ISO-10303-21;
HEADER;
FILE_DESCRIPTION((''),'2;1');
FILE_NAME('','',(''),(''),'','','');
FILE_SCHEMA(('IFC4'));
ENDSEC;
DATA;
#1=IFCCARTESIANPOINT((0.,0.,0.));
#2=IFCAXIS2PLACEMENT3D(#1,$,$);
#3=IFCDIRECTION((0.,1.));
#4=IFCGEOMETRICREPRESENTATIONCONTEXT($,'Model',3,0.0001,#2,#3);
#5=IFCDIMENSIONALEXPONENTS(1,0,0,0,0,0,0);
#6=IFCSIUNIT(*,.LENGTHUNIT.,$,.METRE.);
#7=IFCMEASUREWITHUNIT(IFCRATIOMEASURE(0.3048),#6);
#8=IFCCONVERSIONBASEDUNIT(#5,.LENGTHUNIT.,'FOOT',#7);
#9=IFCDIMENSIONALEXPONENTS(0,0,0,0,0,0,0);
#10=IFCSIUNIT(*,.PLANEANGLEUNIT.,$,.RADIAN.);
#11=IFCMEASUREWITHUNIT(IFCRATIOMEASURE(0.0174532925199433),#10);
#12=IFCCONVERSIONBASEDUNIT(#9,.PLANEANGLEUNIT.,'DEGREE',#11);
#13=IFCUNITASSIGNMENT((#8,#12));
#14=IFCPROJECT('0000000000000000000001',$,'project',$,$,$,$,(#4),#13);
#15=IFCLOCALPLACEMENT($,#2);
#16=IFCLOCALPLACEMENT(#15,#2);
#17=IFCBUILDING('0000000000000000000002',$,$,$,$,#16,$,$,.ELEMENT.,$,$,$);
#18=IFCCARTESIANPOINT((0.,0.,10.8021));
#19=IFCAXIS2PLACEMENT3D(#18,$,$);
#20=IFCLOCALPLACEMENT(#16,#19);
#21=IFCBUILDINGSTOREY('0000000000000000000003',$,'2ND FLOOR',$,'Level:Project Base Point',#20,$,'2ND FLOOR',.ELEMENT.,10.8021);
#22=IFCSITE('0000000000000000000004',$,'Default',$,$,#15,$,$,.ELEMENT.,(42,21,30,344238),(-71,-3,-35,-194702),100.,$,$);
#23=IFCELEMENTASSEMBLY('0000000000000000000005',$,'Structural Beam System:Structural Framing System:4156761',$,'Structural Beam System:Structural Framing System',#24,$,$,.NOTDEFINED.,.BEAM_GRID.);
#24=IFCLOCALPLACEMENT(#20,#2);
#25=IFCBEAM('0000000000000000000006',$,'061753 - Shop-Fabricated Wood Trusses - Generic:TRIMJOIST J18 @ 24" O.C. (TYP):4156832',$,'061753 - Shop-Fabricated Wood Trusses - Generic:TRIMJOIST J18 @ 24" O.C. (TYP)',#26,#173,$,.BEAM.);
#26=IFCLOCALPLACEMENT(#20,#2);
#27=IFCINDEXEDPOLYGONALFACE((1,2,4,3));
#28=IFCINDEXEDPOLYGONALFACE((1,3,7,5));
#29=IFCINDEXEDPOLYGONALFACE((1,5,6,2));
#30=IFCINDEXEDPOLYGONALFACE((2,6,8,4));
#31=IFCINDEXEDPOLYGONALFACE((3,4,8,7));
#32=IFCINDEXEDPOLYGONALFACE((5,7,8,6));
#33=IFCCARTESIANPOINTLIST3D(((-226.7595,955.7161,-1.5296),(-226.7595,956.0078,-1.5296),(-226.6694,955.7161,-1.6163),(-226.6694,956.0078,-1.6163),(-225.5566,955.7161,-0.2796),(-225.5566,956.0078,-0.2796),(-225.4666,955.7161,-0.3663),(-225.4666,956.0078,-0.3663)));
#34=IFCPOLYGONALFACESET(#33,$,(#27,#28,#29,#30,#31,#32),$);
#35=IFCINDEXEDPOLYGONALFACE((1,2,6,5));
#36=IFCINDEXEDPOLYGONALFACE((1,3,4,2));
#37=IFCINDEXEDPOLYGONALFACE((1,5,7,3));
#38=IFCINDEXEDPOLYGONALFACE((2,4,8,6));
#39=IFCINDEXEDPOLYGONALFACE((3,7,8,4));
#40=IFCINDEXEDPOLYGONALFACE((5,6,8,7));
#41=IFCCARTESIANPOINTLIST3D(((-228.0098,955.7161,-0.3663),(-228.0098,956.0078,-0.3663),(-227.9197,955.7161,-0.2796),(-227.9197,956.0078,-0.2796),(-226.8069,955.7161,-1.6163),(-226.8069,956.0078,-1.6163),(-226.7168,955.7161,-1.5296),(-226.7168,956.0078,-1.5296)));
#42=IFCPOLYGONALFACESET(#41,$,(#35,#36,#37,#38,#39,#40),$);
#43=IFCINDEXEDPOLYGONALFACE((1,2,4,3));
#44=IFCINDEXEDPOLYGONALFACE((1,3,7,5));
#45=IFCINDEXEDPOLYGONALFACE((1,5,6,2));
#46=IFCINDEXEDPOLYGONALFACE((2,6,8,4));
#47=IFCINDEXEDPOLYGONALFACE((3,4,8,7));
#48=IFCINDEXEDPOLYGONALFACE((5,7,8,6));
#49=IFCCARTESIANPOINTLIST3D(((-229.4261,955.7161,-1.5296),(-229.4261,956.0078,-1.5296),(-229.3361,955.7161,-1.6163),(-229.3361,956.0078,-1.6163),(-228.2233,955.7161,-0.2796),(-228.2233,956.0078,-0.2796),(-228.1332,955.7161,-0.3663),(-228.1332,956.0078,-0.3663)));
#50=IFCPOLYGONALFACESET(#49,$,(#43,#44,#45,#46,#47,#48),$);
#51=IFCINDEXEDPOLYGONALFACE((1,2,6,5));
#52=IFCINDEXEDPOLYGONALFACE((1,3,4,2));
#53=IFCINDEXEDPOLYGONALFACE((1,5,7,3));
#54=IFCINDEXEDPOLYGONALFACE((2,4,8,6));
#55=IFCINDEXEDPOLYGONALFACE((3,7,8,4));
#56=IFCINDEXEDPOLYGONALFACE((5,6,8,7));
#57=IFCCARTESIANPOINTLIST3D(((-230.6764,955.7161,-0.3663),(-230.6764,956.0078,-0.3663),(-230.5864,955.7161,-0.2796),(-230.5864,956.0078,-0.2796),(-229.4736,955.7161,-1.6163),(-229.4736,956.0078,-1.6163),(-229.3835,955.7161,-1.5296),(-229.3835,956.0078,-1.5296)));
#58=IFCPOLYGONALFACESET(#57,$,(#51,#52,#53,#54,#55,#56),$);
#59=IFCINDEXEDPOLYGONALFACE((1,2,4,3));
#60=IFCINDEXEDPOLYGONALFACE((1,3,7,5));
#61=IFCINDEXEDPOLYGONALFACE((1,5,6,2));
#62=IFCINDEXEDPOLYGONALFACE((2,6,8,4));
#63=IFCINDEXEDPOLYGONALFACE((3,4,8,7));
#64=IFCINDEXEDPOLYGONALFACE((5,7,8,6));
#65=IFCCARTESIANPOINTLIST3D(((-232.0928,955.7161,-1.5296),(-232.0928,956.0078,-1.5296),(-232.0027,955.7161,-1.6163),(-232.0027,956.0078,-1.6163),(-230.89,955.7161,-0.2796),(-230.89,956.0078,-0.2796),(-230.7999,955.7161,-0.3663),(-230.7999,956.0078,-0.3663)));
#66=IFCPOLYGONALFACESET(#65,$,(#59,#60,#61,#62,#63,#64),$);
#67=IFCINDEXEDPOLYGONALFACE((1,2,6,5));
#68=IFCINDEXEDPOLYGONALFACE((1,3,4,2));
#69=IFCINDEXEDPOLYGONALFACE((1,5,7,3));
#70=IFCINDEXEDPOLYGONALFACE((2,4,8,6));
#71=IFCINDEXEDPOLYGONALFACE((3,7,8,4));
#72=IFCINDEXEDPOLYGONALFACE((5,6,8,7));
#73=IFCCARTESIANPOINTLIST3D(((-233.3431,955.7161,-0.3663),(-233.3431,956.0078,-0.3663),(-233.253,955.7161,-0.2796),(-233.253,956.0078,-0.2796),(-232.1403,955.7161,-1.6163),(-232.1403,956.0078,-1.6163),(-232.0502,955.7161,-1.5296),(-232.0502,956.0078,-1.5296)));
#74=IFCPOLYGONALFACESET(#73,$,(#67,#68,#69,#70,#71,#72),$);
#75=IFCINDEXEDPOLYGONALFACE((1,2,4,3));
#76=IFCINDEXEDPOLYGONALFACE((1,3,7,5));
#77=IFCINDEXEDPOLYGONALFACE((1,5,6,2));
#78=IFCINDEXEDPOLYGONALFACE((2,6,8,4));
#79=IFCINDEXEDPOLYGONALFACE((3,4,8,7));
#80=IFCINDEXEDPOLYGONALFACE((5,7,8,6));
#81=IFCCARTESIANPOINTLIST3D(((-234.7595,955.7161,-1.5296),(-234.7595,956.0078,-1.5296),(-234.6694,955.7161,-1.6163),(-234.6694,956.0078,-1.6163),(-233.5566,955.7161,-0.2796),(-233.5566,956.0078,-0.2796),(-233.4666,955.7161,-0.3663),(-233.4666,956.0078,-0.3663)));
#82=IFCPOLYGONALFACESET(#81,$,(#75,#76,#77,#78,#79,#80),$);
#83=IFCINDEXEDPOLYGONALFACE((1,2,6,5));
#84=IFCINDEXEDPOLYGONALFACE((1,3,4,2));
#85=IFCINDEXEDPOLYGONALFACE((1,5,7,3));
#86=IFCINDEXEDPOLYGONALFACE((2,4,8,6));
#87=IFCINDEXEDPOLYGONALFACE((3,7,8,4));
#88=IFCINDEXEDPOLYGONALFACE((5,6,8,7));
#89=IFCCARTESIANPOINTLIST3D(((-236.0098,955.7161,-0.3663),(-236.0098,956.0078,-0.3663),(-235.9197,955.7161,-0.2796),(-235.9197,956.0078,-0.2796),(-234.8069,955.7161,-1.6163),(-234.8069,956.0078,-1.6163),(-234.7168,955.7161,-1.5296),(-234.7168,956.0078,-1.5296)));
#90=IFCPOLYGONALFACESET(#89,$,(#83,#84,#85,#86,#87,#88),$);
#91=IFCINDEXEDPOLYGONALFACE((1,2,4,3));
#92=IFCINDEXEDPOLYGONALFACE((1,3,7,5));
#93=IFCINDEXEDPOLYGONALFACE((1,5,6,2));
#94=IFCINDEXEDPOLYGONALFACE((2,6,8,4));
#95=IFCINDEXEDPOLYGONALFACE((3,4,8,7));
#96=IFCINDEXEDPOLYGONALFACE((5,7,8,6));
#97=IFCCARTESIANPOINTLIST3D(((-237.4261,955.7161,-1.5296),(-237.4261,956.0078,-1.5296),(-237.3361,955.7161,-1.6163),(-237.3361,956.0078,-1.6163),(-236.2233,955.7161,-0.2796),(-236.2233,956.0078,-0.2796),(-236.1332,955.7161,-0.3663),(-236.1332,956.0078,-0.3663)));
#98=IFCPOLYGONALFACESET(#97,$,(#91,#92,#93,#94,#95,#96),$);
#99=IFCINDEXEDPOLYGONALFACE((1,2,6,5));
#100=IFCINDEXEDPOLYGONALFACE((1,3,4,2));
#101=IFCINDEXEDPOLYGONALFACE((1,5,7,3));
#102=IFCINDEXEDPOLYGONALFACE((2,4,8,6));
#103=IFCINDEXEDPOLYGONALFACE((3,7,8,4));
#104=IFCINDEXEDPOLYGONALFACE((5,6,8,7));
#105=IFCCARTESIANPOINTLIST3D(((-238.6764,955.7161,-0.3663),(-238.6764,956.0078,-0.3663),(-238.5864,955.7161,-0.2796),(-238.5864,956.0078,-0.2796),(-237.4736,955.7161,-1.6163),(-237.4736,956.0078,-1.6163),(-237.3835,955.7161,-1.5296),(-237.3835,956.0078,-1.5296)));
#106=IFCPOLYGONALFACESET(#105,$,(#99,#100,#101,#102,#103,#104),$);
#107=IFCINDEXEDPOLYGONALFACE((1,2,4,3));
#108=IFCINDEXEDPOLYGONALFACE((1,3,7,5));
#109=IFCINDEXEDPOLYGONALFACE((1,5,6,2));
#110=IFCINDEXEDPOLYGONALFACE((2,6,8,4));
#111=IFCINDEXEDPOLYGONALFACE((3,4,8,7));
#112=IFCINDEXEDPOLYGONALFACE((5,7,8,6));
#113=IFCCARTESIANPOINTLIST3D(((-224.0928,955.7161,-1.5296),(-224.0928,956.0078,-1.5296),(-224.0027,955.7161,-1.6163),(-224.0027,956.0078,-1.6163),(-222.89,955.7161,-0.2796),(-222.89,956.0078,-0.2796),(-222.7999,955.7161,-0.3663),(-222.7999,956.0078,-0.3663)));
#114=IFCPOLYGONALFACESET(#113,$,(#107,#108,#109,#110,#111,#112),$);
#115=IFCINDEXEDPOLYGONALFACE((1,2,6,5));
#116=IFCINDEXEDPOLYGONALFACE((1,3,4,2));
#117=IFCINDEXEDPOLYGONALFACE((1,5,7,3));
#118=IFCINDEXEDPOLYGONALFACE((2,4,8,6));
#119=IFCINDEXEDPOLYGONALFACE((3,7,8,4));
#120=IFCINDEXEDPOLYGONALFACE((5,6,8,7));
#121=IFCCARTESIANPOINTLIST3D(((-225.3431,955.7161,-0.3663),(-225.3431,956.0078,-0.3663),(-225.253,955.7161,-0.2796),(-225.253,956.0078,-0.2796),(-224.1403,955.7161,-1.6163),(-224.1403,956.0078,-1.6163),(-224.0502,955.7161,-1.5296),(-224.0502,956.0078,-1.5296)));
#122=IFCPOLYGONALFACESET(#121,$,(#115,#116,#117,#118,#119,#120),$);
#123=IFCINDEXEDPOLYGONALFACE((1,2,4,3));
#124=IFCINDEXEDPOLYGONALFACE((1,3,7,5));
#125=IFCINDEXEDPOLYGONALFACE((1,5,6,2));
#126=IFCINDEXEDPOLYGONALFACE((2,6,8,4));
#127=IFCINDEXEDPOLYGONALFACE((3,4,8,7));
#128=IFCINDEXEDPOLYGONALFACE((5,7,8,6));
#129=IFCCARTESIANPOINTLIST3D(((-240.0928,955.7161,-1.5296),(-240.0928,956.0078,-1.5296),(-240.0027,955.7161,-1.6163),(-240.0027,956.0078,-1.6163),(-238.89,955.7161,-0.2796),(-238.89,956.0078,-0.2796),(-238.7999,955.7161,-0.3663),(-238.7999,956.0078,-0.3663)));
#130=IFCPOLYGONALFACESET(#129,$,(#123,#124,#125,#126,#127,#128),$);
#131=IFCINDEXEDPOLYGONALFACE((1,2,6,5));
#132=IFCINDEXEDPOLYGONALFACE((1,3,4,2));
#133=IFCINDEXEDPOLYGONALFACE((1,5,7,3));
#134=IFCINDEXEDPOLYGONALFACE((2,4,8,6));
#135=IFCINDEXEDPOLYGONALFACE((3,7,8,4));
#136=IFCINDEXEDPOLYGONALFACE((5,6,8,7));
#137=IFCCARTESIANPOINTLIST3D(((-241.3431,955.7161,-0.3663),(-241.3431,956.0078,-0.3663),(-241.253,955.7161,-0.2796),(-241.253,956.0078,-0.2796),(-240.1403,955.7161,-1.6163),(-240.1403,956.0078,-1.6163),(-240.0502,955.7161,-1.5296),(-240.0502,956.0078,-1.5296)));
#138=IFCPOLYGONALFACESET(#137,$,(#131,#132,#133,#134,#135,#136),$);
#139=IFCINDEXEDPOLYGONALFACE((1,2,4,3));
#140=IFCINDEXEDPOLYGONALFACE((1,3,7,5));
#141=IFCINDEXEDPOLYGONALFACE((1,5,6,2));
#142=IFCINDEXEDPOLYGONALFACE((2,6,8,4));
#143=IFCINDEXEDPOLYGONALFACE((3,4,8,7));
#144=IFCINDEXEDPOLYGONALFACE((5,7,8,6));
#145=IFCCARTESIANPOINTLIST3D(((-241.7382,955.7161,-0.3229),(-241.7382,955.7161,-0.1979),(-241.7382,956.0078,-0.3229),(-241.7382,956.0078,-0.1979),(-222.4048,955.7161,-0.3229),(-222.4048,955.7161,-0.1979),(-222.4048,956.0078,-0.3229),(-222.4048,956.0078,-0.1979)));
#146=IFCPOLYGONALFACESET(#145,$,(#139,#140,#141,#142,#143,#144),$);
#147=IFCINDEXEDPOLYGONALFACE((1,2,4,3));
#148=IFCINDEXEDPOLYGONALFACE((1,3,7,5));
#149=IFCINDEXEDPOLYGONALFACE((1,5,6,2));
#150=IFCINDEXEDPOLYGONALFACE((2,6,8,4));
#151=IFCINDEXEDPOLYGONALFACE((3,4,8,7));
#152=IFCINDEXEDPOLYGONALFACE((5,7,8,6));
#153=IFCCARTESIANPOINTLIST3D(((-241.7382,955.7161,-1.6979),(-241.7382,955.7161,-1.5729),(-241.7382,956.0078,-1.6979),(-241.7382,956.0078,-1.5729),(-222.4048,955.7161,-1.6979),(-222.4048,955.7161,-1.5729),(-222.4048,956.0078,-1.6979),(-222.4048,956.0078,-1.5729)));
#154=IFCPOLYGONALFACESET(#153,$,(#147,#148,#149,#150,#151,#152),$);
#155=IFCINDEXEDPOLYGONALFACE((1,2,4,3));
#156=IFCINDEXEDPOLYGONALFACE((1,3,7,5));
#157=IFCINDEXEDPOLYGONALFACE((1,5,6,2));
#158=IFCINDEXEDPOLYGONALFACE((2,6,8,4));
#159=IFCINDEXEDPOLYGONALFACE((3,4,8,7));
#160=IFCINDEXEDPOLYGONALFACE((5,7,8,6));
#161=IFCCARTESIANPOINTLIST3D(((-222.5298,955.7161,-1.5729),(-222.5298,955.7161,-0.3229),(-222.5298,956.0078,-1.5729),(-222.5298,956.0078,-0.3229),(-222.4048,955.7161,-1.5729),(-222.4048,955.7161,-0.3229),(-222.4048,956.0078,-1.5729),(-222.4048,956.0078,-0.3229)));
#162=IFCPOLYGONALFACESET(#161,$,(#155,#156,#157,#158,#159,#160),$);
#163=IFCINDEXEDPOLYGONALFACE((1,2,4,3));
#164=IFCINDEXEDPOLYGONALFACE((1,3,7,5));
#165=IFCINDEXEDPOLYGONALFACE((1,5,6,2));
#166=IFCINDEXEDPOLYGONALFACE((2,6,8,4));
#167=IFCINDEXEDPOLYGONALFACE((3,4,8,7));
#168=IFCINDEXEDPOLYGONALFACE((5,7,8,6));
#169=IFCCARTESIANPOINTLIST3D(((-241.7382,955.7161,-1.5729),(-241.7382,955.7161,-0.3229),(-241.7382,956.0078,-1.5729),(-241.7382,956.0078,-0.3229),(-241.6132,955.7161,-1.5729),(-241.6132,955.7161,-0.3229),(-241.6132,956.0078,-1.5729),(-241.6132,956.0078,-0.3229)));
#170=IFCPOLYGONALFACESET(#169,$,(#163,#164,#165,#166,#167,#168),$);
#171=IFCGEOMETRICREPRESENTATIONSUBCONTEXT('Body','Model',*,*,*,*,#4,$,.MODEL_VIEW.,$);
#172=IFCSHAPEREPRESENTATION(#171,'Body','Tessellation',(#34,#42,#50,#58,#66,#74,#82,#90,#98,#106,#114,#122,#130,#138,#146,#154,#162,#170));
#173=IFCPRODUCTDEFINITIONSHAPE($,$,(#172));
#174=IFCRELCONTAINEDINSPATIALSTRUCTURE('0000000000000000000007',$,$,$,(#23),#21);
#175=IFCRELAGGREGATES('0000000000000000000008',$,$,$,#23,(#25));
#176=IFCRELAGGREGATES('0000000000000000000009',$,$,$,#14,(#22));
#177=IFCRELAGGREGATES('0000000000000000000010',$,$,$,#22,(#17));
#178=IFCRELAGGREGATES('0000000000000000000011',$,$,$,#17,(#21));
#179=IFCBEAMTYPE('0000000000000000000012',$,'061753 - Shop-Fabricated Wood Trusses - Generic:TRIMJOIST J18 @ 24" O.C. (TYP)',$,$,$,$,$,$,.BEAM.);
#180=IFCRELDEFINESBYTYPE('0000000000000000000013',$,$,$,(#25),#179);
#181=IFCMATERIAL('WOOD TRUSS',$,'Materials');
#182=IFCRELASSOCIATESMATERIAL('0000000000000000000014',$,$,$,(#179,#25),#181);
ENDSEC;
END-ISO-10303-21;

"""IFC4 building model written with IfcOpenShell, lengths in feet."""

from ifc_helpers import new_model, entity, si_unit, converted_unit, direction, frame, frame_2d, origin, origin_2d_with_axis, place, context, subcontext, project, spatial, rectangle, extrude, source, transform, mapped, material, material_profile, profile_set, profile_usage, type_object, type_shapes, element, aggregate, save


model = new_model("IFC4")

# Units and contexts
model_context = context("Model", 3, precision=0.0001, world=origin(), true_north=direction((0.0, 1.0)))
body_context = subcontext(model_context, "Body", "Model", "MODEL_VIEW")
ifc_project = project(units=[converted_unit("LENGTHUNIT", "FOOT", entity("IfcRatioMeasure", 0.3048), si_unit("LENGTHUNIT", "METRE"), dimensions=[1, 0, 0, 0, 0, 0, 0]), converted_unit("PLANEANGLEUNIT", "DEGREE", entity("IfcRatioMeasure", 0.0174532925199433), si_unit("PLANEANGLEUNIT", "RADIAN"), dimensions=[0, 0, 0, 0, 0, 0, 0])], contexts=[model_context])

# Site, building, storey
site_placement = place(None, origin())
site = spatial("IfcSite", under=ifc_project, at=site_placement, Name="Default", CompositionType="ELEMENT", RefLatitude=(42, 21, 30, 344238), RefLongitude=(-71, -3, -35, -194702), RefElevation=100.0)
building_placement = place(site_placement, origin())
building = spatial("IfcBuilding", under=site, at=building_placement, CompositionType="ELEMENT")
storey_placement = place(building_placement, frame((0.0, 0.0, 10.8021)))
storey = spatial("IfcBuildingStorey", under=building, at=storey_placement, Name="2ND FLOOR", ObjectType="Level:Project Base Point", LongName="2ND FLOOR", CompositionType="ELEMENT", Elevation=10.8021)

# Element assembly, beam
assembly_1_placement = place(storey_placement, origin())
assembly_1 = element("IfcElementAssembly", 1, at=assembly_1_placement, inside=storey, Name="Structural Beam System:Structural Framing System:4156761", ObjectType="Structural Beam System:Structural Framing System", AssemblyPlace="NOTDEFINED", PredefinedType="BEAM_GRID")
ifc_material_1 = material(Name="WOOD TRUSS", Category="Materials")
ifc_material_profile_1 = material_profile(ifc_material_1, rectangle(XDim=1.7347, YDim=0.125, at=frame_2d((0.0, 0.0), x_axis=(1.0, 0.0))), Name="TRIMJOIST J18 @ 24\" O.C. (TYP)")
ifc_material_profile_2 = material_profile(ifc_material_1, rectangle(XDim=1.7347, YDim=0.125, at=frame_2d((0.0, 0.0), x_axis=(1.0, 0.0))), Name="TRIMJOIST J18 @ 24\" O.C. (TYP)")
ifc_material_profile_3 = material_profile(ifc_material_1, rectangle(XDim=1.7347, YDim=0.125, at=frame_2d((0.0, 0.0), x_axis=(1.0, 0.0))), Name="TRIMJOIST J18 @ 24\" O.C. (TYP)")
ifc_material_profile_4 = material_profile(ifc_material_1, rectangle(XDim=1.7347, YDim=0.125, at=frame_2d((0.0, 0.0), x_axis=(1.0, 0.0))), Name="TRIMJOIST J18 @ 24\" O.C. (TYP)")
ifc_material_profile_5 = material_profile(ifc_material_1, rectangle(XDim=1.7347, YDim=0.125, at=frame_2d((0.0, 0.0), x_axis=(1.0, 0.0))), Name="TRIMJOIST J18 @ 24\" O.C. (TYP)")
ifc_material_profile_6 = material_profile(ifc_material_1, rectangle(XDim=1.7347, YDim=0.125, at=frame_2d((0.0, 0.0), x_axis=(1.0, 0.0))), Name="TRIMJOIST J18 @ 24\" O.C. (TYP)")
ifc_material_profile_7 = material_profile(ifc_material_1, rectangle(XDim=1.7347, YDim=0.125, at=frame_2d((0.0, 0.0), x_axis=(1.0, 0.0))), Name="TRIMJOIST J18 @ 24\" O.C. (TYP)")
ifc_material_profile_8 = material_profile(ifc_material_1, rectangle(XDim=1.7347, YDim=0.125, at=frame_2d((0.0, 0.0), x_axis=(1.0, 0.0))), Name="TRIMJOIST J18 @ 24\" O.C. (TYP)")
ifc_material_profile_9 = material_profile(ifc_material_1, rectangle(XDim=1.7347, YDim=0.125, at=frame_2d((0.0, 0.0), x_axis=(1.0, 0.0))), Name="TRIMJOIST J18 @ 24\" O.C. (TYP)")
ifc_material_profile_10 = material_profile(ifc_material_1, rectangle(XDim=1.7347, YDim=0.125, at=origin_2d_with_axis()), Name="TRIMJOIST J18 @ 24\" O.C. (TYP)")
ifc_material_profile_11 = material_profile(ifc_material_1, rectangle(XDim=0.125, YDim=0.2917, at=origin_2d_with_axis()), Name="TRIMJOIST J18 @ 24\" O.C. (TYP)")
ifc_material_profile_12 = material_profile(ifc_material_1, rectangle(XDim=0.125, YDim=0.2917, at=origin_2d_with_axis()), Name="TRIMJOIST J18 @ 24\" O.C. (TYP)")
ifc_material_profile_13 = material_profile(ifc_material_1, rectangle(XDim=1.25, YDim=0.2917, at=origin_2d_with_axis()), Name="TRIMJOIST J18 @ 24\" O.C. (TYP)")
ifc_material_profile_14 = material_profile(ifc_material_1, rectangle(XDim=1.25, YDim=0.2917, at=origin_2d_with_axis()), Name="TRIMJOIST J18 @ 24\" O.C. (TYP)")
ifc_profile_set_1 = profile_set([ifc_material_profile_1, ifc_material_profile_2, ifc_material_profile_3, ifc_material_profile_4, ifc_material_profile_5, ifc_material_profile_6, ifc_material_profile_7, ifc_material_profile_8, ifc_material_profile_9, ifc_material_profile_10, ifc_material_profile_11, ifc_material_profile_12, ifc_material_profile_13, ifc_material_profile_14], Name="TRIMJOIST J18 @ 24\" O.C. (TYP)")
ifc_profile_usage_1 = profile_usage(ifc_profile_set_1, cardinal=8)
beam_type_1 = type_object("IfcBeamType", Name="061753 - Shop-Fabricated Wood Trusses - Generic:TRIMJOIST J18 @ 24\" O.C. (TYP)", PredefinedType="BEAM", material=ifc_profile_set_1)
shared_shape_1 = source(origin(), body_context, "Body", "SweptSolid", [
    extrude(rectangle(XDim=1.7347, YDim=0.125, at=frame_2d((0.0, 0.0), x_axis=(1.0, 0.0))), frame((5.9585, -0.1458, 0.0), z_axis=(0.0, 1.0, 0.0), x_axis=(0.693383, 0.0, 0.720569)), (0.0, 0.0, 1.0), 0.2917),
    extrude(rectangle(XDim=1.7347, YDim=0.125, at=origin_2d_with_axis()), frame((4.7082, -0.1458, 0.0), z_axis=(0.0, 1.0, 0.0), x_axis=(0.693383, 0.0, -0.720569)), (0.0, 0.0, 1.0), 0.2917),
    extrude(rectangle(XDim=1.7347, YDim=0.125, at=frame_2d((0.0, 0.0), x_axis=(1.0, 0.0))), frame((3.2918, -0.1458, 0.0), z_axis=(0.0, 1.0, 0.0), x_axis=(0.693383, 0.0, 0.720569)), (0.0, 0.0, 1.0), 0.2917),
    extrude(rectangle(XDim=1.7347, YDim=0.125, at=frame_2d((0.0, 0.0), x_axis=(1.0, 0.0))), frame((2.0415, -0.1458, 0.0), z_axis=(0.0, 1.0, 0.0), x_axis=(0.693383, 0.0, -0.720569)), (0.0, 0.0, 1.0), 0.2917),
    extrude(rectangle(XDim=1.7347, YDim=0.125, at=frame_2d((0.0, 0.0), x_axis=(1.0, 0.0))), frame((0.6251, -0.1458, 0.0), z_axis=(0.0, 1.0, 0.0), x_axis=(0.693383, 0.0, 0.720569)), (0.0, 0.0, 1.0), 0.2917),
    extrude(rectangle(XDim=1.7347, YDim=0.125, at=frame_2d((0.0, 0.0), x_axis=(1.0, 0.0))), frame((-0.6251, -0.1458, 0.0), z_axis=(0.0, 1.0, 0.0), x_axis=(0.693383, 0.0, -0.720569)), (0.0, 0.0, 1.0), 0.2917),
    extrude(rectangle(XDim=1.7347, YDim=0.125, at=frame_2d((0.0, 0.0), x_axis=(1.0, 0.0))), frame((-2.0415, -0.1458, 0.0), z_axis=(0.0, 1.0, 0.0), x_axis=(0.693383, 0.0, 0.720569)), (0.0, 0.0, 1.0), 0.2917),
    extrude(rectangle(XDim=1.7347, YDim=0.125, at=origin_2d_with_axis()), frame((-3.2918, -0.1458, 0.0), z_axis=(0.0, 1.0, 0.0), x_axis=(0.693383, 0.0, -0.720569)), (0.0, 0.0, 1.0), 0.2917),
    extrude(rectangle(XDim=1.7347, YDim=0.125, at=frame_2d((0.0, 0.0), x_axis=(1.0, 0.0))), frame((-4.7082, -0.1458, 0.0), z_axis=(0.0, 1.0, 0.0), x_axis=(0.693383, 0.0, 0.720569)), (0.0, 0.0, 1.0), 0.2917),
    extrude(rectangle(XDim=1.7347, YDim=0.125, at=frame_2d((0.0, 0.0), x_axis=(1.0, 0.0))), frame((-5.9585, -0.1458, 0.0), z_axis=(0.0, 1.0, 0.0), x_axis=(0.693383, 0.0, -0.720569)), (0.0, 0.0, 1.0), 0.2917),
    extrude(rectangle(XDim=1.7347, YDim=0.125, at=frame_2d((0.0, 0.0), x_axis=(1.0, 0.0))), frame((8.6251, -0.1458, 0.0), z_axis=(0.0, 1.0, 0.0), x_axis=(0.693383, 0.0, 0.720569)), (0.0, 0.0, 1.0), 0.2917),
    extrude(rectangle(XDim=1.7347, YDim=0.125, at=origin_2d_with_axis()), frame((7.3749, -0.1458, 0.0), z_axis=(0.0, 1.0, 0.0), x_axis=(0.693383, 0.0, -0.720569)), (0.0, 0.0, 1.0), 0.2917),
    extrude(rectangle(XDim=1.7347, YDim=0.125, at=frame_2d((0.0, 0.0), x_axis=(1.0, 0.0))), frame((-7.3749, -0.1458, 0.0), z_axis=(0.0, 1.0, 0.0), x_axis=(0.693383, 0.0, 0.720569)), (0.0, 0.0, 1.0), 0.2917),
    extrude(rectangle(XDim=1.7347, YDim=0.125, at=origin_2d_with_axis()), frame((-8.6251, -0.1458, 0.0), z_axis=(0.0, 1.0, 0.0), x_axis=(0.693383, 0.0, -0.720569)), (0.0, 0.0, 1.0), 0.2917),
    extrude(rectangle(XDim=0.125, YDim=0.2917, at=origin_2d_with_axis()), frame((-9.6667, 0.0, 0.6875), z_axis=(1.0, 0.0, 0.0), x_axis=(0.0, 0.0, -1.0)), (0.0, 0.0, 1.0), 19.3333),
    extrude(rectangle(XDim=0.125, YDim=0.2917, at=origin_2d_with_axis()), frame((-9.6667, 0.0, -0.6875), z_axis=(1.0, 0.0, 0.0), x_axis=(0.0, 0.0, -1.0)), (0.0, 0.0, 1.0), 19.3333),
    extrude(rectangle(XDim=1.25, YDim=0.2917, at=origin_2d_with_axis()), frame((9.5417, 0.0, 0.0), z_axis=(1.0, 0.0, 0.0), x_axis=(0.0, 0.0, -1.0)), (0.0, 0.0, 1.0), 0.125),
    extrude(rectangle(XDim=1.25, YDim=0.2917, at=origin_2d_with_axis()), frame((-9.6667, 0.0, 0.0), z_axis=(1.0, 0.0, 0.0), x_axis=(0.0, 0.0, -1.0)), (0.0, 0.0, 1.0), 0.125),
])
type_shapes(beam_type_1, [shared_shape_1])
beam_1_placement = place(assembly_1_placement, frame((-232.0715, 955.8619, -0.9479)))
beam_1 = element("IfcBeam", 2, at=beam_1_placement, type_object=beam_type_1, material=ifc_profile_usage_1, Name="061753 - Shop-Fabricated Wood Trusses - Generic:TRIMJOIST J18 @ 24\" O.C. (TYP):4156832", ObjectType="061753 - Shop-Fabricated Wood Trusses - Generic:TRIMJOIST J18 @ 24\" O.C. (TYP)", PredefinedType="BEAM", context=body_context, shape_type="MappedRepresentation", body=[
    mapped(shared_shape_1, transform((0.0, 0.0, 0.0), scale=1.0)),
])
aggregate(assembly_1, [beam_1])

save(model, "model.ifc")
